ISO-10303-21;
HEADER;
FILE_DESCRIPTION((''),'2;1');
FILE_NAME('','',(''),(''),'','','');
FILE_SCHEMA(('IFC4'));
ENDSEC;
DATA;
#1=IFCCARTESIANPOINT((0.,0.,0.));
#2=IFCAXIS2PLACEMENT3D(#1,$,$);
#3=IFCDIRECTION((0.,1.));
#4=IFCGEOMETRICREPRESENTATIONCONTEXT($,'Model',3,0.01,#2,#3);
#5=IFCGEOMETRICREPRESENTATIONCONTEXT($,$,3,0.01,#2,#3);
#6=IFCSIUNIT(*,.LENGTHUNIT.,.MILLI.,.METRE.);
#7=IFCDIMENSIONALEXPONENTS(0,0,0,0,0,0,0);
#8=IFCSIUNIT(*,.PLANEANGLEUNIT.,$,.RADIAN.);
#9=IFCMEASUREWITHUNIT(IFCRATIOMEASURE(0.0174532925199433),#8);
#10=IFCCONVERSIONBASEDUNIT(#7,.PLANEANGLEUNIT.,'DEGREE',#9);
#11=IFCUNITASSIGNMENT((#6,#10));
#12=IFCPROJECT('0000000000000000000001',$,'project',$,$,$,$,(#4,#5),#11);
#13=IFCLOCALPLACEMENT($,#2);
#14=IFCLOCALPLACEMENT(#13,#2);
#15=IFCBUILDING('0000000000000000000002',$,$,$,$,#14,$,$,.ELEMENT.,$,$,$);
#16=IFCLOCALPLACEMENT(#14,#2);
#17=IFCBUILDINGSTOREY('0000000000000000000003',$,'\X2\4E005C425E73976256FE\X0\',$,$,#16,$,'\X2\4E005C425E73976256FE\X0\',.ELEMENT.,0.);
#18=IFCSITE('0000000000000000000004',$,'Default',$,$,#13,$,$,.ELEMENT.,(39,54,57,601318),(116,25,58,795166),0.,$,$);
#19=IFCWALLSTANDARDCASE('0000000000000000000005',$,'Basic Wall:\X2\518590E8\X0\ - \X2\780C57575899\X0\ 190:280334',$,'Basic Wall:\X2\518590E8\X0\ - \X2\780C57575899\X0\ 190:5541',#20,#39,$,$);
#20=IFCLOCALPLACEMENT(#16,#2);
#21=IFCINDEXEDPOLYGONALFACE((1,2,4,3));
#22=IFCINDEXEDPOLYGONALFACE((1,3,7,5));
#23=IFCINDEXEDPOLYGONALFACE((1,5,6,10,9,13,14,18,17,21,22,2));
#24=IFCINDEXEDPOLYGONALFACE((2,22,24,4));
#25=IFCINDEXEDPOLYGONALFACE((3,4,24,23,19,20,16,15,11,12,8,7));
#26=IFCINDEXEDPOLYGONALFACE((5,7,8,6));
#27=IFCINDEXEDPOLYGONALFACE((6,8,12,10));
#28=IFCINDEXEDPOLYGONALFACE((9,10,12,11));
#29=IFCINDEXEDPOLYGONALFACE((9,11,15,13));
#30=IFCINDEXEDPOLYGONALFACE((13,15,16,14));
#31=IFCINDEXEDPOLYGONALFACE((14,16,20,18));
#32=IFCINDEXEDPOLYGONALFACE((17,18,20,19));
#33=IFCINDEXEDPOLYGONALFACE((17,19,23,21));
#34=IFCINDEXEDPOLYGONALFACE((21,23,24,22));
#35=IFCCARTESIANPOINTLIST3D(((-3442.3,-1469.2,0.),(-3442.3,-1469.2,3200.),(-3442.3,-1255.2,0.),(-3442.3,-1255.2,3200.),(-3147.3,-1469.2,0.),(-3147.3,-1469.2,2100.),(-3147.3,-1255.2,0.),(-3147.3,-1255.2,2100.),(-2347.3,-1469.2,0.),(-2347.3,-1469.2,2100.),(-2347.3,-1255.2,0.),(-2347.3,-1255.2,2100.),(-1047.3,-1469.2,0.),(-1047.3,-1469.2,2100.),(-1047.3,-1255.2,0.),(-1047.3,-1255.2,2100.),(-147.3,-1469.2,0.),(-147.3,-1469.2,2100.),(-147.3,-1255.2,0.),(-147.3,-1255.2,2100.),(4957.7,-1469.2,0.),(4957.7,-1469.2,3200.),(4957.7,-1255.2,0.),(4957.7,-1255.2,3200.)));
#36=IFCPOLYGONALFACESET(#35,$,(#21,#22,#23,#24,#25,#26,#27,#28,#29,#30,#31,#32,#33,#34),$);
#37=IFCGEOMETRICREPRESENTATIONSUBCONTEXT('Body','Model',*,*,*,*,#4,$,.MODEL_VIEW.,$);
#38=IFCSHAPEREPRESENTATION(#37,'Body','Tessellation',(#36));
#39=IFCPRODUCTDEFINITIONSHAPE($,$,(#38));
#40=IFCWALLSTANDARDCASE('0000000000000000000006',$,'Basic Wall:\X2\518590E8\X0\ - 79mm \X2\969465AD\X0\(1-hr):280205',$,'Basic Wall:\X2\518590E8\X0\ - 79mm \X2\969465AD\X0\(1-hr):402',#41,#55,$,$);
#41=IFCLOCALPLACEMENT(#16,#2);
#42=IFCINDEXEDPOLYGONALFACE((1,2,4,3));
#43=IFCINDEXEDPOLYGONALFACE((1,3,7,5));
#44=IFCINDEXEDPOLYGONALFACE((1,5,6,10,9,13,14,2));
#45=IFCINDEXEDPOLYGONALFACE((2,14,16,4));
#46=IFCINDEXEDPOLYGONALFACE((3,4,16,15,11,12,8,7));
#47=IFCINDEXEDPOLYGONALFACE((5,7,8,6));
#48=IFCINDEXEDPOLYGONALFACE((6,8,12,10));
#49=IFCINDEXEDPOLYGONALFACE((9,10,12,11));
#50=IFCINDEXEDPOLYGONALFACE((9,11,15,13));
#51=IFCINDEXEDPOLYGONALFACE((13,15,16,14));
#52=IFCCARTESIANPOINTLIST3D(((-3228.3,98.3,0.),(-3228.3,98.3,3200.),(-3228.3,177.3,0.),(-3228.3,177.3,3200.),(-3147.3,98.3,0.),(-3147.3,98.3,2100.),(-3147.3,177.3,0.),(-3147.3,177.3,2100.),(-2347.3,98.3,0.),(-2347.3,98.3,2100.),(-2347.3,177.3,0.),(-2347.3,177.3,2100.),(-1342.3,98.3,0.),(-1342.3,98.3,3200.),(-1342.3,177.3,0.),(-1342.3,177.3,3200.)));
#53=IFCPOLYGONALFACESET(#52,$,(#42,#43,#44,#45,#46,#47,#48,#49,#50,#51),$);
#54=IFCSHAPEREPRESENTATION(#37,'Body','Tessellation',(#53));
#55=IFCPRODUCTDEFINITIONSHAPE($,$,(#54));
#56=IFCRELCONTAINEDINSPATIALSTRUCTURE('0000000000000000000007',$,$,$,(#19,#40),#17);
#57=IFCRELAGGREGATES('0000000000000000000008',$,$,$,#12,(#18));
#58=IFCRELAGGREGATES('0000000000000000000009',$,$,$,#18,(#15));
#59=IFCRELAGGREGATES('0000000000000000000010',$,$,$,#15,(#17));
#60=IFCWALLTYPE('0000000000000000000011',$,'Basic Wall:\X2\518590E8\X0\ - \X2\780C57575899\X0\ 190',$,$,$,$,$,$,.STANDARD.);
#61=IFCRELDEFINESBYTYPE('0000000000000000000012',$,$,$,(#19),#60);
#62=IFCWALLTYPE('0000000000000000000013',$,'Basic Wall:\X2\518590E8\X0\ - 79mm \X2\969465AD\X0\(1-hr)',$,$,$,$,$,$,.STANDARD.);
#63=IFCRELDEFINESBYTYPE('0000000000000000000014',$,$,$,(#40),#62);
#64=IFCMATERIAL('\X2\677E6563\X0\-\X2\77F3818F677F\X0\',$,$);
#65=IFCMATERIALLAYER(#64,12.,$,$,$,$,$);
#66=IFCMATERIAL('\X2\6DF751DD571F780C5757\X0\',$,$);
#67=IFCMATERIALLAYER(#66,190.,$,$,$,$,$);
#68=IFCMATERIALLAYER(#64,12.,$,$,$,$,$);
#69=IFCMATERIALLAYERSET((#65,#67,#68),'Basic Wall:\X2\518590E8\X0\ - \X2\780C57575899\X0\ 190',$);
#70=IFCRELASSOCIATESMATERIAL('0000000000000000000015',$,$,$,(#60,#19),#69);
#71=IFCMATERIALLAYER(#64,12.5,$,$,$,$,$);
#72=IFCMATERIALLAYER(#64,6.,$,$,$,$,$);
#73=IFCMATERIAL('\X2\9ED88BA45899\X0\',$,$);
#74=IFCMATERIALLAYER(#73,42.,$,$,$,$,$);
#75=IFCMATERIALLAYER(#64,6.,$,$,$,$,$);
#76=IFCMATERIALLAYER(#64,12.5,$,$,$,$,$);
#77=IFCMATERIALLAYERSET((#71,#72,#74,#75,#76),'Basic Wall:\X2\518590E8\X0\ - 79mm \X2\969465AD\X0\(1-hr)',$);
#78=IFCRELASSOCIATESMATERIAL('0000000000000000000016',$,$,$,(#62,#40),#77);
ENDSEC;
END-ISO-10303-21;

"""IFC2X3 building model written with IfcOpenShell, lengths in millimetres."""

from ifc_helpers import new_model, entity, si_unit, converted_unit, direction, frame, frame_2d, origin, place, context, subcontext, project, spatial, rectangle, extrude, material, layer, layer_set, layer_usage, type_object, element, save


model = new_model("IFC2X3")

# Units and contexts
model_context = context("Model", 3, precision=0.01, world=origin(), true_north=direction((0.0, 1.0)))
context_of_model = context(None, 3, precision=0.01, world=origin(), true_north=direction((0.0, 1.0)))
body_context = subcontext(model_context, "Body", "Model", "MODEL_VIEW")
ifc_project = project(units=[si_unit("LENGTHUNIT", "METRE", prefix="MILLI"), converted_unit("PLANEANGLEUNIT", "DEGREE", entity("IfcRatioMeasure", 0.0174532925199433), si_unit("PLANEANGLEUNIT", "RADIAN"), dimensions=[0, 0, 0, 0, 0, 0, 0])], contexts=[model_context, context_of_model])

# Site, building, storey
site_placement = place(None, origin())
site = spatial("IfcSite", under=ifc_project, at=site_placement, Name="Default", CompositionType="ELEMENT", RefLatitude=(39, 54, 57, 601318), RefLongitude=(116, 25, 58, 795166), RefElevation=0.0)
building_placement = place(site_placement, origin())
building = spatial("IfcBuilding", under=site, at=building_placement, CompositionType="ELEMENT")
storey_placement = place(building_placement, origin())
storey = spatial("IfcBuildingStorey", under=building, at=storey_placement, Name="一层平面图", LongName="一层平面图", CompositionType="ELEMENT", Elevation=0.0)

# Shared definitions
ifc_material_1 = material(Name="松散-石膏板")
ifc_layer_1 = layer(ifc_material_1, 12.0)
ifc_material_2 = material(Name="混凝土砌块")
ifc_layer_2 = layer(ifc_material_2, 190.0)
ifc_layer_3 = layer(ifc_material_1, 12.0)
ifc_layer_set_1 = layer_set([ifc_layer_1, ifc_layer_2, ifc_layer_3], Name="Basic Wall:内部 - 砌块墙 190")
wall_type_1 = type_object("IfcWallType", Name="Basic Wall:内部 - 砌块墙 190", PredefinedType="STANDARD", material=ifc_layer_set_1)

# Wall, openings
ifc_layer_usage_1 = layer_usage(ifc_layer_set_1, "AXIS2", "NEGATIVE", 107.0)
wall_1_placement = place(storey_placement, frame((-3442.3, -1362.2, 0.0)))
wall_1 = element("IfcWallStandardCase", 1, at=wall_1_placement, inside=storey, type_object=wall_type_1, material=ifc_layer_usage_1, Name="Basic Wall:内部 - 砌块墙 190:280334", ObjectType="Basic Wall:内部 - 砌块墙 190:5541", context=body_context, shape_type="SweptSolid", body=[
    extrude(rectangle(XDim=8400.0, YDim=214.0, at=frame_2d((4200.0, 0.0), x_axis=(-1.0, 0.0))), origin(), (0.0, 0.0, 1.0), 3200.0),
])
opening_1_placement = place(wall_1_placement, frame((2395.0, -107.0, 0.0)))
element("IfcOpeningElement", 2, at=opening_1_placement, cuts=wall_1, ObjectType="Opening", context=body_context, shape_type="SweptSolid", body=[
    extrude(rectangle(XDim=900.0, YDim=2100.0, at=frame_2d((1050.0, 450.0), x_axis=(0.0, 1.0))), frame((0.0, 0.0, 0.0), z_axis=(0.0, 1.0, 0.0), x_axis=(0.0, 0.0, 1.0)), (0.0, 0.0, 1.0), 214.0),
])
opening_2_placement = place(wall_1_placement, frame((295.0, -107.0, 0.0)))
element("IfcOpeningElement", 3, at=opening_2_placement, cuts=wall_1, ObjectType="Opening", context=body_context, shape_type="SweptSolid", body=[
    extrude(rectangle(XDim=800.0, YDim=2100.0, at=frame_2d((1050.0, 400.0), x_axis=(0.0, 1.0))), frame((0.0, 0.0, 0.0), z_axis=(0.0, 1.0, 0.0), x_axis=(0.0, 0.0, 1.0)), (0.0, 0.0, 1.0), 214.0),
])

# Wall, opening
ifc_layer_4 = layer(ifc_material_1, 12.5)
ifc_layer_5 = layer(ifc_material_1, 6.0)
ifc_material_3 = material(Name="默认墙")
ifc_layer_6 = layer(ifc_material_3, 42.0)
ifc_layer_7 = layer(ifc_material_1, 6.0)
ifc_layer_8 = layer(ifc_material_1, 12.5)
ifc_layer_set_2 = layer_set([ifc_layer_4, ifc_layer_5, ifc_layer_6, ifc_layer_7, ifc_layer_8], Name="Basic Wall:内部 - 79mm 隔断(1-hr)")
ifc_layer_usage_2 = layer_usage(ifc_layer_set_2, "AXIS2", "NEGATIVE", 39.5)
wall_type_2 = type_object("IfcWallType", Name="Basic Wall:内部 - 79mm 隔断(1-hr)", PredefinedType="STANDARD", material=ifc_layer_set_2)
wall_2_placement = place(storey_placement, frame((-3228.3, 137.8, 0.0)))
wall_2 = element("IfcWallStandardCase", 4, at=wall_2_placement, inside=storey, type_object=wall_type_2, material=ifc_layer_usage_2, Name="Basic Wall:内部 - 79mm 隔断(1-hr):280205", ObjectType="Basic Wall:内部 - 79mm 隔断(1-hr):402", context=body_context, shape_type="SweptSolid", body=[
    extrude(rectangle(XDim=1886.0, YDim=79.0, at=frame_2d((943.0, 0.0), x_axis=(-1.0, 0.0))), origin(), (0.0, 0.0, 1.0), 3200.0),
])
opening_3_placement = place(wall_2_placement, frame((81.0, -39.5, 0.0)))
element("IfcOpeningElement", 5, at=opening_3_placement, cuts=wall_2, ObjectType="Opening", context=body_context, shape_type="SweptSolid", body=[
    extrude(rectangle(XDim=800.0, YDim=2100.0, at=frame_2d((1050.0, 400.0), x_axis=(0.0, 1.0))), frame((0.0, 0.0, 0.0), z_axis=(0.0, 1.0, 0.0), x_axis=(0.0, 0.0, 1.0)), (0.0, 0.0, 1.0), 79.0),
])

save(model, "model.ifc")
